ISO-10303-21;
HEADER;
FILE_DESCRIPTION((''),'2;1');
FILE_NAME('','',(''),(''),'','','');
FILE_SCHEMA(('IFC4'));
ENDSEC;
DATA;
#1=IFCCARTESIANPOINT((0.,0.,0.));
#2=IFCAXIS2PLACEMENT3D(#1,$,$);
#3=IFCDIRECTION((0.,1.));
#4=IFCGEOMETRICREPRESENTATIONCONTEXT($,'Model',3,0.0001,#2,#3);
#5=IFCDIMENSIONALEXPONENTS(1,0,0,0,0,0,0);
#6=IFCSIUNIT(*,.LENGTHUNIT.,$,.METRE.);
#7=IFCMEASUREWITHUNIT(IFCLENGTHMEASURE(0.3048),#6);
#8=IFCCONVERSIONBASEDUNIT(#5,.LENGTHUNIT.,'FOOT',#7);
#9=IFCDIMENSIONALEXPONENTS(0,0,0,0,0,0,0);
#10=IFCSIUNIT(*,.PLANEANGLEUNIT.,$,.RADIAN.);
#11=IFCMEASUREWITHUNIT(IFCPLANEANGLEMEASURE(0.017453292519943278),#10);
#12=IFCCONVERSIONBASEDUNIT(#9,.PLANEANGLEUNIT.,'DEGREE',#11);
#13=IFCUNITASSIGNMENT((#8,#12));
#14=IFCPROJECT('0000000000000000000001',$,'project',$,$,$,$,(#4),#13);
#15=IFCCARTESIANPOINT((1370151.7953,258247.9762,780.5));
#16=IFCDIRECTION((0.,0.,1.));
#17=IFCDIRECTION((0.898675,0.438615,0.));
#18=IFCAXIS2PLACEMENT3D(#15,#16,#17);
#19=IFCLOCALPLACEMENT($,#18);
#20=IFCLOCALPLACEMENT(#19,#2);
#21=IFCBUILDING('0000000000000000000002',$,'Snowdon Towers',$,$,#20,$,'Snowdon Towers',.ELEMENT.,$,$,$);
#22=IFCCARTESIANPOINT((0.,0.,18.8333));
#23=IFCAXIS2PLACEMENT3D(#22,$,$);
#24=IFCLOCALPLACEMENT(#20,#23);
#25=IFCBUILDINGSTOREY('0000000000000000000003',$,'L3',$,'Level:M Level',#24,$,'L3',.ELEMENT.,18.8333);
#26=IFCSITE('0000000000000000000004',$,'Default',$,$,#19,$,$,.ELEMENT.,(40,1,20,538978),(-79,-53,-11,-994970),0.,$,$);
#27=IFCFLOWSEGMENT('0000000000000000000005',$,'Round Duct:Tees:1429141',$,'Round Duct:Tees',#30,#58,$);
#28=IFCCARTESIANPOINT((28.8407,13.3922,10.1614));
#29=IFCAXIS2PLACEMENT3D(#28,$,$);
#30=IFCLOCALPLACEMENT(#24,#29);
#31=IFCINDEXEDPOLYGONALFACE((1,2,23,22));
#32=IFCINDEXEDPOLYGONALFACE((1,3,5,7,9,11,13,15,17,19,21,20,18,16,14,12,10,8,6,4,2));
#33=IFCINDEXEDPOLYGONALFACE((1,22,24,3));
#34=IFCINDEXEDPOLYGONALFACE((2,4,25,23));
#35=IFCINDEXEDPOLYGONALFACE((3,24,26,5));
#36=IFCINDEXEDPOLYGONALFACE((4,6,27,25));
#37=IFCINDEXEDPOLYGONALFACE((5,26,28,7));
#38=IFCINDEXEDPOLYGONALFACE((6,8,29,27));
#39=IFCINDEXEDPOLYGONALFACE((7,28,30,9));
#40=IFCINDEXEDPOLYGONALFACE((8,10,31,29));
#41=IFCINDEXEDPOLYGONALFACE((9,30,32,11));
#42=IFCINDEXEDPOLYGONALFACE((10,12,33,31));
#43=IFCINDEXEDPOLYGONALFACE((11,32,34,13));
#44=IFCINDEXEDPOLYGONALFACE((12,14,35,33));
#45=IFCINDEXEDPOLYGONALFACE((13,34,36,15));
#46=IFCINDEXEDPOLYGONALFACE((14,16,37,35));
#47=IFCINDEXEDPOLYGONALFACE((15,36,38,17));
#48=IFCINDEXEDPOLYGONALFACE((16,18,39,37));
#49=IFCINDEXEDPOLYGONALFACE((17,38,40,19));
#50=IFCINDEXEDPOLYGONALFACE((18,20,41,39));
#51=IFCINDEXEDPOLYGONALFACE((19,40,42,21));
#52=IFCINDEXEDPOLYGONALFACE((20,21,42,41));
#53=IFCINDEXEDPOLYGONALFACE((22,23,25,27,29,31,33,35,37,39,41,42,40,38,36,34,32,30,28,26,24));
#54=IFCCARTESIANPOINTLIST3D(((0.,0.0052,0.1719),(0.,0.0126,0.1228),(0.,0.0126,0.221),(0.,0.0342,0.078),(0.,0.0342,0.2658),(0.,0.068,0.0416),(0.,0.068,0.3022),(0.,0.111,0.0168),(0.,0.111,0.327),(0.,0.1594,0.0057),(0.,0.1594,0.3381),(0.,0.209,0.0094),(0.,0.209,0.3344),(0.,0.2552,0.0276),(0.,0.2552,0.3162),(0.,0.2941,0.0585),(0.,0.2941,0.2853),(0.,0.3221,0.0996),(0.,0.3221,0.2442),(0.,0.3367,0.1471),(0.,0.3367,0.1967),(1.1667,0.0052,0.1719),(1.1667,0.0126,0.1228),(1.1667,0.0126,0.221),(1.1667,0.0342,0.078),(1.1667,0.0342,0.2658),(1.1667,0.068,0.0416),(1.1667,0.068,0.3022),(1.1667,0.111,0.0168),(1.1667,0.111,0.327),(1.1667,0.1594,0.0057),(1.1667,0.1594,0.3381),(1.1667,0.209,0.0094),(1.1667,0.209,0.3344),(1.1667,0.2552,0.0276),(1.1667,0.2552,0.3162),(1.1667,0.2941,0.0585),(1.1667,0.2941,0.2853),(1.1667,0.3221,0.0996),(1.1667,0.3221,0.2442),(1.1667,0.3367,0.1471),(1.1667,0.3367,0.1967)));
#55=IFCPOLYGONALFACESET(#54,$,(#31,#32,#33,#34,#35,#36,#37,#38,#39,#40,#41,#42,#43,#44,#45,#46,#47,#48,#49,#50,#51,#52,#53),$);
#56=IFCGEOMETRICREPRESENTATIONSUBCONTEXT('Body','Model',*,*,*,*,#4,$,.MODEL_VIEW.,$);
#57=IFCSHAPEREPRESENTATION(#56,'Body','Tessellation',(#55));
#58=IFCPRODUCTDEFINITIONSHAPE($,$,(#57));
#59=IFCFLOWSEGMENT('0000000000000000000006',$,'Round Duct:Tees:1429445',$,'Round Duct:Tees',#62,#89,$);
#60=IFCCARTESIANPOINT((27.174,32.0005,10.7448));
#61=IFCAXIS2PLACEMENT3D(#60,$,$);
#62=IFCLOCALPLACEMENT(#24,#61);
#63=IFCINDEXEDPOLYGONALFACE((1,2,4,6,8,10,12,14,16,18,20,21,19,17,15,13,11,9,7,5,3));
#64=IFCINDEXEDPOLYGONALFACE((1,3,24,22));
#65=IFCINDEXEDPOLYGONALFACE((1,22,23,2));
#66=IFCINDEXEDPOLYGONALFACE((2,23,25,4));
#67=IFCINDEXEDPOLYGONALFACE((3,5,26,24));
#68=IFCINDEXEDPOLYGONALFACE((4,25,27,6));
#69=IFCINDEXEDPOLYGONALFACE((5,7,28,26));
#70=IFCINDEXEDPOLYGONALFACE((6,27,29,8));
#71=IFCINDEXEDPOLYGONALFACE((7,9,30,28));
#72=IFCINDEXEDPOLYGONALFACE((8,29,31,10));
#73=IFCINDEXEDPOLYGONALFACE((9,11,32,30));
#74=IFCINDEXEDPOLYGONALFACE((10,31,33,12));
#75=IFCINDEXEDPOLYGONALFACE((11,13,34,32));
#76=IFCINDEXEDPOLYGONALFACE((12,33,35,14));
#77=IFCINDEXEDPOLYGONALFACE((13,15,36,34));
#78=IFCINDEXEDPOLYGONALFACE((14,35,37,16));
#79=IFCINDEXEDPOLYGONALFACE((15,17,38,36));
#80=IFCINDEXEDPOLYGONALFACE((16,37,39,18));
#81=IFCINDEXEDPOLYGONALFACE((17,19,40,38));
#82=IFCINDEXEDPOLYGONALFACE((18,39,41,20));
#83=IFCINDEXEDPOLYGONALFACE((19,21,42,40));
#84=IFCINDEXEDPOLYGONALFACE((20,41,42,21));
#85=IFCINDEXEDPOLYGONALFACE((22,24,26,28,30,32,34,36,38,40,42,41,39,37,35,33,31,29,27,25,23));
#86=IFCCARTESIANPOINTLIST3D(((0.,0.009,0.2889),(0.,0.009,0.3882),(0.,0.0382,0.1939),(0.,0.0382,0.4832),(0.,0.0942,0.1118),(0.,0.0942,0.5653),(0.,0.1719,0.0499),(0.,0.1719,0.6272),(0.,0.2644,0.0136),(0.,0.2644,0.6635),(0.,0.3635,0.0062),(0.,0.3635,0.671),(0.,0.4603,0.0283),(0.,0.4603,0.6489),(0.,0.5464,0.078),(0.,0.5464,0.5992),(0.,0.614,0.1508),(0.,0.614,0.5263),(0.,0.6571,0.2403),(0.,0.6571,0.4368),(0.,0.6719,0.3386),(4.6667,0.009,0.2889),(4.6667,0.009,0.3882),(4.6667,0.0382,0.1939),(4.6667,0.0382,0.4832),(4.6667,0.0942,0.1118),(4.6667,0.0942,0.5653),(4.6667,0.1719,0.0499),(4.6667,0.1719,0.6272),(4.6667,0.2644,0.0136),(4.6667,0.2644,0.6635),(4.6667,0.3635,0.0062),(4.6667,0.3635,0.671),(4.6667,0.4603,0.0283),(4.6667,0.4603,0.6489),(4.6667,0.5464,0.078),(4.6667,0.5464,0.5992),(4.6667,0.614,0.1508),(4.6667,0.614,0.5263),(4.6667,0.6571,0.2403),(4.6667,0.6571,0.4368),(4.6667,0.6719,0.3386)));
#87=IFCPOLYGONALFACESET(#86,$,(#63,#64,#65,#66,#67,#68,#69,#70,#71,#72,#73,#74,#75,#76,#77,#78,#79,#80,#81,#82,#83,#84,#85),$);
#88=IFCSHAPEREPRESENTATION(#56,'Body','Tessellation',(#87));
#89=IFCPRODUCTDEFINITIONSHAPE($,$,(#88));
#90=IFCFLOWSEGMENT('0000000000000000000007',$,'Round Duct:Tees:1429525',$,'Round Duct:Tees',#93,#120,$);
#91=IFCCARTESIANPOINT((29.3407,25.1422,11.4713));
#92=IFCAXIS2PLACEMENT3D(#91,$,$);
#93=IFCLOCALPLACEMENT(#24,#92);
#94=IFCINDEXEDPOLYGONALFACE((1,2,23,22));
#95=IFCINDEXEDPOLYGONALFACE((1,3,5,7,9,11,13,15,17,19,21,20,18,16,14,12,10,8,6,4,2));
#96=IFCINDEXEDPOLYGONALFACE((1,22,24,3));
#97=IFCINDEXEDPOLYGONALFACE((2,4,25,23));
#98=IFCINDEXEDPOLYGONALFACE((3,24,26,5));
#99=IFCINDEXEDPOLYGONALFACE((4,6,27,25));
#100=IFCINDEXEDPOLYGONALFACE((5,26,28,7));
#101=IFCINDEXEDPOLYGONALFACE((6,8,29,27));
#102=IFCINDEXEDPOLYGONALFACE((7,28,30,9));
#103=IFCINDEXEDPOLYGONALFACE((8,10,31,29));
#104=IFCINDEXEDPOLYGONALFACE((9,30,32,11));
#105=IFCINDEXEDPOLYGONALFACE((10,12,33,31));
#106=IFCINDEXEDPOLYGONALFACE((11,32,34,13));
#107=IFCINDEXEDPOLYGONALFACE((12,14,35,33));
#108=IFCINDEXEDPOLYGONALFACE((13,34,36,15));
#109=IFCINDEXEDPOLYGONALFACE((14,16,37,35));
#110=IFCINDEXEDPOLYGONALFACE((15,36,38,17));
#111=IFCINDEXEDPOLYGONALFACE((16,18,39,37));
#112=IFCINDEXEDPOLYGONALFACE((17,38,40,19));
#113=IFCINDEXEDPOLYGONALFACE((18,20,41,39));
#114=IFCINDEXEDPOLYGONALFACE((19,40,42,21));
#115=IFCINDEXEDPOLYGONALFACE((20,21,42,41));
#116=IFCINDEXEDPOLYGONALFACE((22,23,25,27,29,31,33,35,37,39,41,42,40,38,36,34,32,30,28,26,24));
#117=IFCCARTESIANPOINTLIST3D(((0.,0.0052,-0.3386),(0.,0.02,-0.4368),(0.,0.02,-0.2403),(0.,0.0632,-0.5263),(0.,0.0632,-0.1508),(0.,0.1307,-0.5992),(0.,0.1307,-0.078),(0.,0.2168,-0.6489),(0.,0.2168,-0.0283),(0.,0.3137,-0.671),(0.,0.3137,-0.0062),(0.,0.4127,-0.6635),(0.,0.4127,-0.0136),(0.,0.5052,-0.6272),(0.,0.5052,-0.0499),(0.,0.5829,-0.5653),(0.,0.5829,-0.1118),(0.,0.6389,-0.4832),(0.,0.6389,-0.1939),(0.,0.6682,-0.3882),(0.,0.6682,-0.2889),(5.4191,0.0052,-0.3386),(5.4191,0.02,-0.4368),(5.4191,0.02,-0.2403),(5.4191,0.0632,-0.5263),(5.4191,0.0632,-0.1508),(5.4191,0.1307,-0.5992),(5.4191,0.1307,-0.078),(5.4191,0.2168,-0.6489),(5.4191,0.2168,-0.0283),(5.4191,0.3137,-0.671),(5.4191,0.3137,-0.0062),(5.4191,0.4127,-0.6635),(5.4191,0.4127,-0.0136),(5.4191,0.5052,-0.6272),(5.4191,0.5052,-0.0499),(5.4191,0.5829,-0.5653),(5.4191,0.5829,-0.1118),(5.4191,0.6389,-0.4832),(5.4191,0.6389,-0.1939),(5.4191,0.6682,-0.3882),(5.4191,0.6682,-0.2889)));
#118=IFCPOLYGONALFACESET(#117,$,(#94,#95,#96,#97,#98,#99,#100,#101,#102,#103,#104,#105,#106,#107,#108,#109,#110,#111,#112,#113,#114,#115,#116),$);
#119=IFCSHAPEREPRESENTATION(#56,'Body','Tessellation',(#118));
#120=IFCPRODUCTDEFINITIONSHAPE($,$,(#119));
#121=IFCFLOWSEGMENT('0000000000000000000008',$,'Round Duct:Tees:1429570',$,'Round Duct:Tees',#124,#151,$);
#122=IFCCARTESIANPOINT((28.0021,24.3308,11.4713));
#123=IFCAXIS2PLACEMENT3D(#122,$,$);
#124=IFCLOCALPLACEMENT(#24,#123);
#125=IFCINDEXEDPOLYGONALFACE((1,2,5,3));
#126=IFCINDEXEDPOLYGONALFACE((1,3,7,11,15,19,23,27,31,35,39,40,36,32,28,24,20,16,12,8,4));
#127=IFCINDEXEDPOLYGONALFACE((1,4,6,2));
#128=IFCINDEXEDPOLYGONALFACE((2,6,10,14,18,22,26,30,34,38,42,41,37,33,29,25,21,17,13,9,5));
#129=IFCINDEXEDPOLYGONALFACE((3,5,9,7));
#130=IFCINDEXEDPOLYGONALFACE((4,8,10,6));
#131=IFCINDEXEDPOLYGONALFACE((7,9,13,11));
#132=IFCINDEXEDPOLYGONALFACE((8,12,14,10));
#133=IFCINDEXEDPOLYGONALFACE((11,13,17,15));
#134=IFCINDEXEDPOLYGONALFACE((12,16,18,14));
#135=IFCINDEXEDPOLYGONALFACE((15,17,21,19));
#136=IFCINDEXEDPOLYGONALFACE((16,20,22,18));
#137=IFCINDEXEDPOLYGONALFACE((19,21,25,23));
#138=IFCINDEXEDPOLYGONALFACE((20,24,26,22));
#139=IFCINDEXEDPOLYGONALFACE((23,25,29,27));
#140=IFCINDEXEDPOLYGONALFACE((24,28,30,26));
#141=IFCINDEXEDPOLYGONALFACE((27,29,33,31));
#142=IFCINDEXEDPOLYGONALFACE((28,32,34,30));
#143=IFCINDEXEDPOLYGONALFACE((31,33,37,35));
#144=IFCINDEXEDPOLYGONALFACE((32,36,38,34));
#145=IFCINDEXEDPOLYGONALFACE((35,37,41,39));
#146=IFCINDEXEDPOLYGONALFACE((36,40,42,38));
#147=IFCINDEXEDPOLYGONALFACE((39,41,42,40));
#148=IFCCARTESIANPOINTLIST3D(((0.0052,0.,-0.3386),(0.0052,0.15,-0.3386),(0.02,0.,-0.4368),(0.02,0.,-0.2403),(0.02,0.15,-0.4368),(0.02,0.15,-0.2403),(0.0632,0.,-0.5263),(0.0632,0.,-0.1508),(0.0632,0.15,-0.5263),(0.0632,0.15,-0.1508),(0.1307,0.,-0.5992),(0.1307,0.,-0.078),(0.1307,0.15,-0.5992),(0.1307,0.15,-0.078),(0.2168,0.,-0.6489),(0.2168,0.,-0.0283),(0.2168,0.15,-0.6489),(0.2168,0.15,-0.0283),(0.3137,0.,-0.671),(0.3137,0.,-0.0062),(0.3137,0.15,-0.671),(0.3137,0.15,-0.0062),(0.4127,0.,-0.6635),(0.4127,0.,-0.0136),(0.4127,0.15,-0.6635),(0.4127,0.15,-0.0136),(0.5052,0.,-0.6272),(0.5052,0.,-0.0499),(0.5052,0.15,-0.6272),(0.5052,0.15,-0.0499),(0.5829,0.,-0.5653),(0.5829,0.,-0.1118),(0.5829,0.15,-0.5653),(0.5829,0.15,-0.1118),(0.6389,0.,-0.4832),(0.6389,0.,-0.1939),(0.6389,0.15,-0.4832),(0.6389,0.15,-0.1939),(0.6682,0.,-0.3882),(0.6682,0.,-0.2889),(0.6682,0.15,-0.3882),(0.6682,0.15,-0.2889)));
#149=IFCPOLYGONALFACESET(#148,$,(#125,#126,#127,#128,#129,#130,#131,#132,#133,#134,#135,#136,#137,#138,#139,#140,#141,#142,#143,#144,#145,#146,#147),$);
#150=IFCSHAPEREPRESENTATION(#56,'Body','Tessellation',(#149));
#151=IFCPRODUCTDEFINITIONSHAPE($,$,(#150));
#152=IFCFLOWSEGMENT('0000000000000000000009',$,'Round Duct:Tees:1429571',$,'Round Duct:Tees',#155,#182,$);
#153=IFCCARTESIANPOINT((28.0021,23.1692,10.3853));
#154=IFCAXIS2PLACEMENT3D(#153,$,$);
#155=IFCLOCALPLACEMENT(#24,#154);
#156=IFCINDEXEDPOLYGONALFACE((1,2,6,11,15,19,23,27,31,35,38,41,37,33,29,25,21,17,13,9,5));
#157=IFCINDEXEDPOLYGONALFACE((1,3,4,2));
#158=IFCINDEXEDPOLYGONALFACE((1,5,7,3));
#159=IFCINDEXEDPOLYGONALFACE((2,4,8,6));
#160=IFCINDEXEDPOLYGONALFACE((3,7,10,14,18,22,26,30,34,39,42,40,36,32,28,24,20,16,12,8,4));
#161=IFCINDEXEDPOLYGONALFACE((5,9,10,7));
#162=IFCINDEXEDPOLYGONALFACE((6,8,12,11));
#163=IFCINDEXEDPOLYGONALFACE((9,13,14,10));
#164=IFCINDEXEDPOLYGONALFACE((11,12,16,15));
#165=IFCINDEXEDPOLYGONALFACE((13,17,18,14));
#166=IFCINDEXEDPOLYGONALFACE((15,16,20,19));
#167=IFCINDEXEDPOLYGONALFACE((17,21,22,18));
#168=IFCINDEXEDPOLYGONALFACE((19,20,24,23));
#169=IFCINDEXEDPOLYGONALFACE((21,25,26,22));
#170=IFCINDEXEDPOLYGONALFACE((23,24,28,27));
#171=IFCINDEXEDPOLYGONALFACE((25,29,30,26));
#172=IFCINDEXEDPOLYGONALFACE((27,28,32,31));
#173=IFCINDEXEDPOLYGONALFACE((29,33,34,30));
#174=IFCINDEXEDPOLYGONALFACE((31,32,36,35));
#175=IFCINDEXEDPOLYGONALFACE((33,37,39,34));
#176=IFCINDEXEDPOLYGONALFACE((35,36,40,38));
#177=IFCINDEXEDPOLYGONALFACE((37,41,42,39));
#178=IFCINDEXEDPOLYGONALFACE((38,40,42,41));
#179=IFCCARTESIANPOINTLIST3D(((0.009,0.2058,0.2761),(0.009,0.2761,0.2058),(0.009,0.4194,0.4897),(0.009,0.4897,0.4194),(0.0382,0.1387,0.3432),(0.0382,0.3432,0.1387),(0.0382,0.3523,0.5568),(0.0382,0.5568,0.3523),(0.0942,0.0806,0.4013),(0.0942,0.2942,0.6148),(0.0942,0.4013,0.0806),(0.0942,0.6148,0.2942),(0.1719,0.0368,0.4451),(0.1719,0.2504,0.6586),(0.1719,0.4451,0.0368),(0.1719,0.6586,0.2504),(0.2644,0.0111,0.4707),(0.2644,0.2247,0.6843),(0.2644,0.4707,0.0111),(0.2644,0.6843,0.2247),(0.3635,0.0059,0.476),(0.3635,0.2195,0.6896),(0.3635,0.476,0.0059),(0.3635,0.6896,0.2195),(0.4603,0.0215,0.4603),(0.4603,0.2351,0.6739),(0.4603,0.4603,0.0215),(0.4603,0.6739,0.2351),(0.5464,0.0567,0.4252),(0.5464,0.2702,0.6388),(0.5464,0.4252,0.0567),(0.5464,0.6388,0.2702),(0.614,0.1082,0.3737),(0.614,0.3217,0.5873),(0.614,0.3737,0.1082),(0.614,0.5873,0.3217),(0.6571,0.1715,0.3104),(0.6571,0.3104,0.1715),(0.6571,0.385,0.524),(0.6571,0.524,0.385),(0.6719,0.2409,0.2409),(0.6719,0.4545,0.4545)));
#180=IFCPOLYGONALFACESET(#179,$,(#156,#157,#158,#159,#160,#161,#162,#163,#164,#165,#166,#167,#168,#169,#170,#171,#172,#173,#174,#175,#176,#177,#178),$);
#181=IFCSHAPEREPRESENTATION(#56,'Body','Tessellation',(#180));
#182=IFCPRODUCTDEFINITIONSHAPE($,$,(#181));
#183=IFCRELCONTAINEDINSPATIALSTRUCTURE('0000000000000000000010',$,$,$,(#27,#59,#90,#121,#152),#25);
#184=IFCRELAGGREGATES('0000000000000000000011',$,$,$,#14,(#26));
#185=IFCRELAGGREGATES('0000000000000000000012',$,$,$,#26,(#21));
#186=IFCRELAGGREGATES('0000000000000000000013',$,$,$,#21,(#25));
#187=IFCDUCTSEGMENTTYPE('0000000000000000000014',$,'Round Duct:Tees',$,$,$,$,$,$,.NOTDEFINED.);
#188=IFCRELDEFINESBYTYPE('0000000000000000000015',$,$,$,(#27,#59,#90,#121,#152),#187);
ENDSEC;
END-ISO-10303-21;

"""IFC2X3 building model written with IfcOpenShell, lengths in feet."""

from ifc_helpers import new_model, entity, si_unit, converted_unit, direction, frame, frame_2d, origin, origin_2d_with_axis, place, context, subcontext, project, spatial, circle, extrude, type_object, element, save


model = new_model("IFC2X3")

# Units and contexts
model_context = context("Model", 3, precision=0.0001, world=origin(), true_north=direction((0.0, 1.0)))
body_context = subcontext(model_context, "Body", "Model", "MODEL_VIEW")
ifc_project = project(units=[converted_unit("LENGTHUNIT", "FOOT", entity("IfcLengthMeasure", 0.3048), si_unit("LENGTHUNIT", "METRE"), dimensions=[1, 0, 0, 0, 0, 0, 0]), converted_unit("PLANEANGLEUNIT", "DEGREE", entity("IfcPlaneAngleMeasure", 0.017453292519943278), si_unit("PLANEANGLEUNIT", "RADIAN"), dimensions=[0, 0, 0, 0, 0, 0, 0])], contexts=[model_context])

# Site, building, storey
site_placement = place(None, frame((1370151.7953, 258247.9762, 780.5), z_axis=(0.0, 0.0, 1.0), x_axis=(0.898675, 0.438615, 0.0)))
site = spatial("IfcSite", under=ifc_project, at=site_placement, Name="Default", CompositionType="ELEMENT", RefLatitude=(40, 1, 20, 538978), RefLongitude=(-79, -53, -11, -994970), RefElevation=0.0)
building_placement = place(site_placement, origin())
building = spatial("IfcBuilding", under=site, at=building_placement, Name="Snowdon Towers", LongName="Snowdon Towers", CompositionType="ELEMENT")
storey_placement = place(building_placement, frame((0.0, 0.0, 18.8333)))
storey = spatial("IfcBuildingStorey", under=building, at=storey_placement, Name="L3", ObjectType="Level:M Level", LongName="L3", CompositionType="ELEMENT", Elevation=18.8333)

# Flow segments
duct_segment_type = type_object("IfcDuctSegmentType", Name="Round Duct:Tees", PredefinedType="NOTDEFINED")
flow_segment_1_placement = place(storey_placement, frame((28.8407, 13.3922, 10.1614)))
element("IfcFlowSegment", 1, at=flow_segment_1_placement, inside=storey, type_object=duct_segment_type, Name="Round Duct:Tees:1429141", ObjectType="Round Duct:Tees", context=body_context, shape_type="SweptSolid", body=[
    extrude(circle(Radius=0.1667, at=frame_2d((0.0, 0.0), x_axis=(1.0, 0.0))), frame((0.0, 0.1719, 0.1719), z_axis=(1.0, 0.0, 0.0), x_axis=(0.0, -1.0, 0.0)), (0.0, 0.0, 1.0), 1.1667),
])
flow_segment_2_placement = place(storey_placement, frame((27.174, 32.0005, 10.7448)))
element("IfcFlowSegment", 2, at=flow_segment_2_placement, inside=storey, type_object=duct_segment_type, Name="Round Duct:Tees:1429445", ObjectType="Round Duct:Tees", context=body_context, shape_type="SweptSolid", body=[
    extrude(circle(Radius=0.3333, at=origin_2d_with_axis()), frame((0.0, 0.3386, 0.3386), z_axis=(1.0, 0.0, 0.0), x_axis=(0.0, 1.0, 0.0)), (0.0, 0.0, 1.0), 4.6667),
])
flow_segment_3_placement = place(storey_placement, frame((29.3407, 25.1422, 11.4713)))
element("IfcFlowSegment", 3, at=flow_segment_3_placement, inside=storey, type_object=duct_segment_type, Name="Round Duct:Tees:1429525", ObjectType="Round Duct:Tees", context=body_context, shape_type="SweptSolid", body=[
    extrude(circle(Radius=0.3333, at=frame_2d((0.0, 0.0), x_axis=(1.0, 0.0))), frame((0.0, 0.3386, -0.3386), z_axis=(1.0, 0.0, 0.0), x_axis=(0.0, -1.0, 0.0)), (0.0, 0.0, 1.0), 5.4191),
])
flow_segment_4_placement = place(storey_placement, frame((28.0021, 24.3308, 11.4713)))
element("IfcFlowSegment", 4, at=flow_segment_4_placement, inside=storey, type_object=duct_segment_type, Name="Round Duct:Tees:1429570", ObjectType="Round Duct:Tees", context=body_context, shape_type="SweptSolid", body=[
    extrude(circle(Radius=0.3333, at=frame_2d((0.0, 0.0), x_axis=(1.0, 0.0))), frame((0.3386, 0.0, -0.3386), z_axis=(0.0, 1.0, 0.0), x_axis=(-1.0, 0.0, 0.0)), (0.0, 0.0, 1.0), 0.15),
])
flow_segment_5_placement = place(storey_placement, frame((28.0021, 23.1692, 10.3853)))
element("IfcFlowSegment", 5, at=flow_segment_5_placement, inside=storey, type_object=duct_segment_type, Name="Round Duct:Tees:1429571", ObjectType="Round Duct:Tees", context=body_context, shape_type="SweptSolid", body=[
    extrude(circle(Radius=0.3333, at=frame_2d((0.0, 0.0), x_axis=(1.0, 0.0))), frame((0.3386, 0.2409, 0.2409), z_axis=(0.0, 0.707107, 0.707107), x_axis=(1.0, 0.0, 0.0)), (0.0, 0.0, 1.0), 0.3021),
])

save(model, "model.ifc")
